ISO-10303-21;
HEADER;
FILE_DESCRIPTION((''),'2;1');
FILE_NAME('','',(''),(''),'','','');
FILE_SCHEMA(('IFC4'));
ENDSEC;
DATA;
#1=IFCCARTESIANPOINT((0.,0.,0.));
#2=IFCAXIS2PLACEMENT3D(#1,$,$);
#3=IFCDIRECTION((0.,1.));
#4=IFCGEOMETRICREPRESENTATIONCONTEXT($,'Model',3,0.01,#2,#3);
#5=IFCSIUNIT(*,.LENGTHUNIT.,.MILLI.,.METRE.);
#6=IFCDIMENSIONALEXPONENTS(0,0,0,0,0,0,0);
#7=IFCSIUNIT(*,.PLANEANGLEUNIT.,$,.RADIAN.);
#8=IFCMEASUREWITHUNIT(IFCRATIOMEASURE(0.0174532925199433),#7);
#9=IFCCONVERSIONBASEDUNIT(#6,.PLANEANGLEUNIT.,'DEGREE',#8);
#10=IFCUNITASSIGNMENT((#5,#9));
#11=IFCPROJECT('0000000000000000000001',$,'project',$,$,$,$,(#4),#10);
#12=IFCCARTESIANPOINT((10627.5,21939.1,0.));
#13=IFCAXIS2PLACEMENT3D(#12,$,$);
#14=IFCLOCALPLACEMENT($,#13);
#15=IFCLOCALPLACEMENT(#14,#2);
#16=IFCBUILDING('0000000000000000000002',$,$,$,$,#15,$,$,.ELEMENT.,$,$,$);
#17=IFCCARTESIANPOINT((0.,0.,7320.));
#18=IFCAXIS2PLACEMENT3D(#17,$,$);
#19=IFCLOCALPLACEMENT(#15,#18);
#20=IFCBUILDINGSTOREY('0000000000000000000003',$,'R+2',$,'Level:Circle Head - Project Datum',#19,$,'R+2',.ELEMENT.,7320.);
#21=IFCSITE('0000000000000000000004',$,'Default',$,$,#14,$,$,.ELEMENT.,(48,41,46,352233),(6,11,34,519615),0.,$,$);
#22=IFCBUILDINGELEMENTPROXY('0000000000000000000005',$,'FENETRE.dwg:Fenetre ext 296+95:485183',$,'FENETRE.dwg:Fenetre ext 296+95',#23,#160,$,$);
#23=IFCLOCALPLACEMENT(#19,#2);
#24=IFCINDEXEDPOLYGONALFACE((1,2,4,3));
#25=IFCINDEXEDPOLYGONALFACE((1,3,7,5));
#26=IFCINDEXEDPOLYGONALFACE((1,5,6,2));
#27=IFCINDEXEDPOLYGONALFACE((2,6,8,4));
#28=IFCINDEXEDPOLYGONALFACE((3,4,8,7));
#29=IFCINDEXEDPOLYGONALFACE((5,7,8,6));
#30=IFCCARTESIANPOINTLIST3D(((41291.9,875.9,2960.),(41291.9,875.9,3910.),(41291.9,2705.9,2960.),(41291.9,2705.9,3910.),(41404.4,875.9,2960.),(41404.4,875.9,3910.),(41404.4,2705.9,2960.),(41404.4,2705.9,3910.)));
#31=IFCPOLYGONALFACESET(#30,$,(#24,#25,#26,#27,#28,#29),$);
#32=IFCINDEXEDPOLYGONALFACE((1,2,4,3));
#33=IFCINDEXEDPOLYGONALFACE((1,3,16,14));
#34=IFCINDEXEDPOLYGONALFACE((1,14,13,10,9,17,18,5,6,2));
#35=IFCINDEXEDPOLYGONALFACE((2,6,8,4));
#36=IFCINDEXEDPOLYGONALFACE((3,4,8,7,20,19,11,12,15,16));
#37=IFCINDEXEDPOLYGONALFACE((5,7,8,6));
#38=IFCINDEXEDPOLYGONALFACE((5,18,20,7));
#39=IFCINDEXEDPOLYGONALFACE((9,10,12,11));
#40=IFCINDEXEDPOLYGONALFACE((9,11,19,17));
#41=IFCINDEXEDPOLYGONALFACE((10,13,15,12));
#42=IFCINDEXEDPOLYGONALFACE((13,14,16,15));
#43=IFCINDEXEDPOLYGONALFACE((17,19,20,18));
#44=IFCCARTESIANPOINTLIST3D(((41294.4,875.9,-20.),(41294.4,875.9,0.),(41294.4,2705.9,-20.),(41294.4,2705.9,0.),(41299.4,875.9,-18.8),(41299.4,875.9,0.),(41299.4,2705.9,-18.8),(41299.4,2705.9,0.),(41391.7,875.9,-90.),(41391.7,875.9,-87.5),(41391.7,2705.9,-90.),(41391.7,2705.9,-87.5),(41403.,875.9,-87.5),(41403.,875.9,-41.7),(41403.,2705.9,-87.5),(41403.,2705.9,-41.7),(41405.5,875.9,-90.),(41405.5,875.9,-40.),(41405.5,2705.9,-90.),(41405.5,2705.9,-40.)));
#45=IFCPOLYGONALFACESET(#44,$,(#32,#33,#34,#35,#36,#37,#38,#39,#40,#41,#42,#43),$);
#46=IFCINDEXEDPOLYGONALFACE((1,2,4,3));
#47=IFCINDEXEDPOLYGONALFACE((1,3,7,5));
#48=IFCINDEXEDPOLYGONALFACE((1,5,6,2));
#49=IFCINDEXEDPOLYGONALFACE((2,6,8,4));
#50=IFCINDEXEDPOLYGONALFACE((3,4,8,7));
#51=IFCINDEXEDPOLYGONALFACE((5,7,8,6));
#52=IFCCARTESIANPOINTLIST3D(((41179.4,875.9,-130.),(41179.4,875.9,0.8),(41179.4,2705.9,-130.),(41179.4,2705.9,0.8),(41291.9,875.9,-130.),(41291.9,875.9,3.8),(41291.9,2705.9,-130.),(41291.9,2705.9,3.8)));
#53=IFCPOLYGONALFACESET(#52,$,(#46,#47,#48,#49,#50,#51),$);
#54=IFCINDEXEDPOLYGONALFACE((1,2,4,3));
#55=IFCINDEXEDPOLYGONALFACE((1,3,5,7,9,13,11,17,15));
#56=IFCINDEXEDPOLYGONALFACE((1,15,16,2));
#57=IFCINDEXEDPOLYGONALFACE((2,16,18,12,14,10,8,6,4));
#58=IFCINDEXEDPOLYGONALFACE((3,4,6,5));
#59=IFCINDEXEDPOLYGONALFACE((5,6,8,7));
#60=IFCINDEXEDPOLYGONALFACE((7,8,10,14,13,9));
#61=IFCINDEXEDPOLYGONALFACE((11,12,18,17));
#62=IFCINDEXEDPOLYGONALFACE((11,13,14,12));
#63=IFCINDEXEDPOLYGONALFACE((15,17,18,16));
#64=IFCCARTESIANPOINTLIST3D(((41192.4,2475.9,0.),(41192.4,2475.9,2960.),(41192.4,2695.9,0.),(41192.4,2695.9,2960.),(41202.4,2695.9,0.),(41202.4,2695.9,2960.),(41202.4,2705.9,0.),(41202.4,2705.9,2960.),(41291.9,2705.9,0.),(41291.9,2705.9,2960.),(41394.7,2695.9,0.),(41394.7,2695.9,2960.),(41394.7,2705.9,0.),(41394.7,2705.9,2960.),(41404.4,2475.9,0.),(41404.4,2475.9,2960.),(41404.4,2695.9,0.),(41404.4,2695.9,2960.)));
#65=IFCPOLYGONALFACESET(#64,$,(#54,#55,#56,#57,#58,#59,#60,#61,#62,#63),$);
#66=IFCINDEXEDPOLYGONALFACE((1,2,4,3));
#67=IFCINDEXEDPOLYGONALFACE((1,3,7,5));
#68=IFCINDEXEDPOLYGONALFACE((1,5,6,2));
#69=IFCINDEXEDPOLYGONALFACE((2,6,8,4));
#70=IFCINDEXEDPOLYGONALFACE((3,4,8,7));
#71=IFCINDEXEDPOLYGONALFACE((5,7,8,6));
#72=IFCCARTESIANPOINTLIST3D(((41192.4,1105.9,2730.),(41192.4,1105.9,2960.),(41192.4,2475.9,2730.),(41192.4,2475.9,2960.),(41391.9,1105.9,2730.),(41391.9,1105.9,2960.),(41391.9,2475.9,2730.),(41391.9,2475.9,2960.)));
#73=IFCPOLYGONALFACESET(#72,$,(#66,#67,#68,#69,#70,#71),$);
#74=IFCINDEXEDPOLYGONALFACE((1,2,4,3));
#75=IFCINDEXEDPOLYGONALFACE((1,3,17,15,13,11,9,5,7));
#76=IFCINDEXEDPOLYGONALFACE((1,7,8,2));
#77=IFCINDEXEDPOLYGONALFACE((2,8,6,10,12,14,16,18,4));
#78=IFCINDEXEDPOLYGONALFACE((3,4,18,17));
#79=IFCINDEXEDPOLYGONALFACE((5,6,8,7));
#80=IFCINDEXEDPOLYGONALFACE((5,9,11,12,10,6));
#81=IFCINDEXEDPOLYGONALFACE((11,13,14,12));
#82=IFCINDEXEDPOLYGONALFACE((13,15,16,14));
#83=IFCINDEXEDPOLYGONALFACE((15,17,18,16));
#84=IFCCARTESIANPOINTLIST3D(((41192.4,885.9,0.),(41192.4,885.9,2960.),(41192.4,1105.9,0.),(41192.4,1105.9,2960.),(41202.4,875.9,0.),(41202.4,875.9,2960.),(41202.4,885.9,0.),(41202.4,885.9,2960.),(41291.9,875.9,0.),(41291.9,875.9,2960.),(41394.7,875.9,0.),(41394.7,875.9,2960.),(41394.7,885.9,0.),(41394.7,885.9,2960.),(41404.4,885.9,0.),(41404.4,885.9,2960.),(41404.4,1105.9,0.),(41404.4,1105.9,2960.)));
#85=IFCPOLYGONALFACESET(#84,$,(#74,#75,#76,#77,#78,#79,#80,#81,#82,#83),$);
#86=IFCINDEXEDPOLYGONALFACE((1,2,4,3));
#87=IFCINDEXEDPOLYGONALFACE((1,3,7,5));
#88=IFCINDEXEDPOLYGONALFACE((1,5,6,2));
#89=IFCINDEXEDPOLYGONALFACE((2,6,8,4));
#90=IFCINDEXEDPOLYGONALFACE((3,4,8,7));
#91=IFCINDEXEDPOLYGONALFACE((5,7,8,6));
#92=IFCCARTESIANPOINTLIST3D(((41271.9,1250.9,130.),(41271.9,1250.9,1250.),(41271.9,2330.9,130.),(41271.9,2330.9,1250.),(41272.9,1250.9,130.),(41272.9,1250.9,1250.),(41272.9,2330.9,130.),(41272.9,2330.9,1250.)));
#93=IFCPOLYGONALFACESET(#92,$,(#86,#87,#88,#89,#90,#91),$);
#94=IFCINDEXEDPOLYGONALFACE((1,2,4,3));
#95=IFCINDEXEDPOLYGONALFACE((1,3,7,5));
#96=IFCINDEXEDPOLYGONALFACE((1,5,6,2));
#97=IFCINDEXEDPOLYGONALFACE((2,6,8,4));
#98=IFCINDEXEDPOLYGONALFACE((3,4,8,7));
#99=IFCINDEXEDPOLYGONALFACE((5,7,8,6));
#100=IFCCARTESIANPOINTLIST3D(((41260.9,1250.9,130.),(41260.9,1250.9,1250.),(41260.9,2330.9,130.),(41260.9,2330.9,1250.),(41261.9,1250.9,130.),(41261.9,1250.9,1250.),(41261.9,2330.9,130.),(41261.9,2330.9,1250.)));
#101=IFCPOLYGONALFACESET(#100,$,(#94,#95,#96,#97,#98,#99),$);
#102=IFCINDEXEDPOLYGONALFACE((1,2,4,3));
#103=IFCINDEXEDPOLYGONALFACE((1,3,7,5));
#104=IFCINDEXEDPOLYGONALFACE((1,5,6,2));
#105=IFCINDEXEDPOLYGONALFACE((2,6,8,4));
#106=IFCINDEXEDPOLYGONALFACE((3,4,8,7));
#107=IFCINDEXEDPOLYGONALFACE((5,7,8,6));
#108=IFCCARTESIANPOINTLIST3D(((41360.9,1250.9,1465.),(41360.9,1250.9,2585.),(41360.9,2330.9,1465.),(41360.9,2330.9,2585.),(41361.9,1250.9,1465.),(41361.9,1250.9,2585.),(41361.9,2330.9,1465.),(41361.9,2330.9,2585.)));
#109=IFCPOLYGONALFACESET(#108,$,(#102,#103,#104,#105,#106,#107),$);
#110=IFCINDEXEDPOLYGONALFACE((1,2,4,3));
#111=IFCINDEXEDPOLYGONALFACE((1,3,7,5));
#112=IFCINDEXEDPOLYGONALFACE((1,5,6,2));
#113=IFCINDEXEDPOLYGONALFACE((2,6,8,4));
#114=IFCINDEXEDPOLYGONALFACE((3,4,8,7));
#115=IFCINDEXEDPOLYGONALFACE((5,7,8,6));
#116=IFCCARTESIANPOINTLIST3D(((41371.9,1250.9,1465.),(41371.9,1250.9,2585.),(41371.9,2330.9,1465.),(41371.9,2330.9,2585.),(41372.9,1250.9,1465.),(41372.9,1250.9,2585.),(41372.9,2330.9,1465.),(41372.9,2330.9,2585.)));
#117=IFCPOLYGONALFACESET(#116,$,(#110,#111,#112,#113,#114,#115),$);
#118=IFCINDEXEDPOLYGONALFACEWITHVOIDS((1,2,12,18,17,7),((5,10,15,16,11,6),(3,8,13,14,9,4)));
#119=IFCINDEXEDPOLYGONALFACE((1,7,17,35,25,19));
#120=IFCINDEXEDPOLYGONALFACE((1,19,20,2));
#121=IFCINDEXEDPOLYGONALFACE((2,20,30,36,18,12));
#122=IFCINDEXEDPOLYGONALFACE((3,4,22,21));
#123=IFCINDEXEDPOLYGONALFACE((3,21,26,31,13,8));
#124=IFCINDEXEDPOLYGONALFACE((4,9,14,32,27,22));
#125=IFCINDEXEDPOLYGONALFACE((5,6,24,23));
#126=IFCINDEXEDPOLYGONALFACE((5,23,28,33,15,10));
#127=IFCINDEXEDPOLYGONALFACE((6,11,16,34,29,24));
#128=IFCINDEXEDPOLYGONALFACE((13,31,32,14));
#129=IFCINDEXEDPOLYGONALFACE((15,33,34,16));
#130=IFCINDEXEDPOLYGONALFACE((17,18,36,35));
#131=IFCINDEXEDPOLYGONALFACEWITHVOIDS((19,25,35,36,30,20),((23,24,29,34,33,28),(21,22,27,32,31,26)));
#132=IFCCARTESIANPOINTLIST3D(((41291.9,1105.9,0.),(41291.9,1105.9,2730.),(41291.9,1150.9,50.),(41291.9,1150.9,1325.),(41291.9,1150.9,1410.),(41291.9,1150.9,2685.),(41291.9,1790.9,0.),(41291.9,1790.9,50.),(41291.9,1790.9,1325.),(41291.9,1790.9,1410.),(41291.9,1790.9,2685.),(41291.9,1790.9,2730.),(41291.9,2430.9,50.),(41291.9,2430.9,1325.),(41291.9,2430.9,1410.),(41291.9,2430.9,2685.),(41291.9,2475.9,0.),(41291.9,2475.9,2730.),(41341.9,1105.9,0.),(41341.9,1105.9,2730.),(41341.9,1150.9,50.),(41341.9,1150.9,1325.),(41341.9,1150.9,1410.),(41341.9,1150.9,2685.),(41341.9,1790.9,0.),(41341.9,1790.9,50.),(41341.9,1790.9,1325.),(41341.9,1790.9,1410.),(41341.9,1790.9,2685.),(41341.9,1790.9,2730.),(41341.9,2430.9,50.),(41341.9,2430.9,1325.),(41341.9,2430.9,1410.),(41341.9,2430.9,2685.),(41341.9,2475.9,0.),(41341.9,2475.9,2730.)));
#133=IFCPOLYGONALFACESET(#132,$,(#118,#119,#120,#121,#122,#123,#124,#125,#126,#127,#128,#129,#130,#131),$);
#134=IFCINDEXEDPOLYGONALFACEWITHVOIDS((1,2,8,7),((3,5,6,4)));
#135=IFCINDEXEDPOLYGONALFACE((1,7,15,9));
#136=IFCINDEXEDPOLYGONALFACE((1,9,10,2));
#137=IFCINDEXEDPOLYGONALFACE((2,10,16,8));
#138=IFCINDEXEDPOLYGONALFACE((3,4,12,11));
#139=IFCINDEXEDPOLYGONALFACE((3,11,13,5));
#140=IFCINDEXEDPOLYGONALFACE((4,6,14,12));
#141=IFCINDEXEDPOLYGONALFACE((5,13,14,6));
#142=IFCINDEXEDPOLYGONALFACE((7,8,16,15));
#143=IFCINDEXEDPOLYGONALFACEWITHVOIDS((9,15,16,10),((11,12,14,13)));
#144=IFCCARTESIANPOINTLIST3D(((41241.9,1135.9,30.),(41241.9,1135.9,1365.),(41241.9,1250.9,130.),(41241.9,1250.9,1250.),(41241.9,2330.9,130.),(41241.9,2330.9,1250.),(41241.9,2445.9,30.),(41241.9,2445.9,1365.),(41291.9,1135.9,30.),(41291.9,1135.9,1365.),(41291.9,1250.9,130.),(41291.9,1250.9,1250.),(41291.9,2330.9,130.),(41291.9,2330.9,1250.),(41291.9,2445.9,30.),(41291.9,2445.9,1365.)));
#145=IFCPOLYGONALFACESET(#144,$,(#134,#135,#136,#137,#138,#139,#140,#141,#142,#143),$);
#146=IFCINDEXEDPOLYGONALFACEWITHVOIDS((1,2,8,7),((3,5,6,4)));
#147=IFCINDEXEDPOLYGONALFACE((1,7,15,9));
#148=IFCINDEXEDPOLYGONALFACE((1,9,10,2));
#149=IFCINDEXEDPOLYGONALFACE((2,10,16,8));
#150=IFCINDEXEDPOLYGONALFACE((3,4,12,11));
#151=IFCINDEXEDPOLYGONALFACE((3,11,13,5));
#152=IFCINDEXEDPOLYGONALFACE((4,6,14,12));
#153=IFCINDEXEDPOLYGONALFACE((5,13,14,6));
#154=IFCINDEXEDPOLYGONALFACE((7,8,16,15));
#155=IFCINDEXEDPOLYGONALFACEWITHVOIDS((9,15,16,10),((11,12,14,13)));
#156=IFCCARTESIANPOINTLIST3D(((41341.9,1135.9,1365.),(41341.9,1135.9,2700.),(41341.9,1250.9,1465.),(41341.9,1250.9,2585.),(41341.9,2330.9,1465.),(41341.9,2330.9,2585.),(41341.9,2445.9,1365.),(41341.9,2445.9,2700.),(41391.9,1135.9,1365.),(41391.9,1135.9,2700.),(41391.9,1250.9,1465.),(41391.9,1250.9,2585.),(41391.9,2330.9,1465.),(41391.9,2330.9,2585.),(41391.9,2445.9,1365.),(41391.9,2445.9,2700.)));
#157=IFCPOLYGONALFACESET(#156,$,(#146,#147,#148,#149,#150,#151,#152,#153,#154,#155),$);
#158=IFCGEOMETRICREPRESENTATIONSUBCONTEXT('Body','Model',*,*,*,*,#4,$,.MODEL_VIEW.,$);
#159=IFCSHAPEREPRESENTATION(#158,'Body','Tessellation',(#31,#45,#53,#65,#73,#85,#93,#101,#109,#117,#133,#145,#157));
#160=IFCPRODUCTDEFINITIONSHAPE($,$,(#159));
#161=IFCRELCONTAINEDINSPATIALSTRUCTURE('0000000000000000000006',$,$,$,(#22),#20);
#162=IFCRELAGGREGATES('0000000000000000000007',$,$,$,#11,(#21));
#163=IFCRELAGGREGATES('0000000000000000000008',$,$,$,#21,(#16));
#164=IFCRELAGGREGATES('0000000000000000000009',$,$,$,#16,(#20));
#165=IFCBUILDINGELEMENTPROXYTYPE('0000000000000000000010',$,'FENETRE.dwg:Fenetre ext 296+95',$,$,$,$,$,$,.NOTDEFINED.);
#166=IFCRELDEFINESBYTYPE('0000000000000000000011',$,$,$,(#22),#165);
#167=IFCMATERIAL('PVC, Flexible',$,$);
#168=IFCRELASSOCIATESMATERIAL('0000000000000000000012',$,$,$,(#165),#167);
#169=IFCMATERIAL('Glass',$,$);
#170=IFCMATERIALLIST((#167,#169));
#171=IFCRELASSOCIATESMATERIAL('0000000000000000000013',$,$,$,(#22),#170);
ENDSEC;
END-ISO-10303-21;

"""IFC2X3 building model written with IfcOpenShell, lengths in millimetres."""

from ifc_helpers import new_model, entity, si_unit, converted_unit, direction, frame, frame_2d, origin, origin_2d_with_axis, place, context, subcontext, project, spatial, polyline, rectangle, outline, extrude, source, transform, mapped, material, material_list, type_object, type_shapes, element, save


model = new_model("IFC2X3")

# Units and contexts
model_context = context("Model", 3, precision=0.01, world=origin(), true_north=direction((0.0, 1.0)))
body_context = subcontext(model_context, "Body", "Model", "MODEL_VIEW")
ifc_project = project(units=[si_unit("LENGTHUNIT", "METRE", prefix="MILLI"), converted_unit("PLANEANGLEUNIT", "DEGREE", entity("IfcRatioMeasure", 0.0174532925199433), si_unit("PLANEANGLEUNIT", "RADIAN"), dimensions=[0, 0, 0, 0, 0, 0, 0])], contexts=[model_context])

# Site, building, storey
site_placement = place(None, frame((10627.5, 21939.1, 0.0)))
site = spatial("IfcSite", under=ifc_project, at=site_placement, Name="Default", CompositionType="ELEMENT", RefLatitude=(48, 41, 46, 352233), RefLongitude=(6, 11, 34, 519615), RefElevation=0.0)
building_placement = place(site_placement, origin())
building = spatial("IfcBuilding", under=site, at=building_placement, CompositionType="ELEMENT")
storey_placement = place(building_placement, frame((0.0, 0.0, 7320.0)))
storey = spatial("IfcBuildingStorey", under=building, at=storey_placement, Name="R+2", ObjectType="Level:Circle Head - Project Datum", LongName="R+2", CompositionType="ELEMENT", Elevation=7320.0)

# Building element proxy
ifc_material_1 = material(Name="PVC, Flexible")
ifc_material_2 = material(Name="Glass")
building_element_proxy_type_1 = type_object("IfcBuildingElementProxyType", Name="FENETRE.dwg:Fenetre ext 296+95", PredefinedType="NOTDEFINED", material=ifc_material_1)
shared_shape_1 = source(origin(), body_context, "Body", "SweptSolid", [
    extrude(rectangle(XDim=112.5, YDim=1830.0, at=origin_2d_with_axis()), frame((-10.4, -56.3, 2960.0), z_axis=(0.0, 0.0, 1.0), x_axis=(0.0, 1.0, 0.0)), (0.0, 0.0, 1.0), 950.0),
    extrude(outline(polyline([(27.5, -64.4), (47.5, -64.4), (47.5, -59.4), (28.8, -59.4), (7.5, 46.7), (-42.5, 46.7), (-42.5, 32.9), (-40.0, 32.9), (-40.0, 44.2), (5.8, 44.2), (27.5, -64.4)])), frame((-925.4, -66.9, -47.5), z_axis=(1.0, 0.0, 0.0), x_axis=(0.0, 0.0, 1.0)), (0.0, 0.0, 1.0), 1830.0),
    extrude(outline(polyline([(-54.5, -66.1), (58.0, -66.1), (54.5, 67.6), (-58.0, 64.6), (-54.5, -66.1)])), frame((-925.4, 56.3, -63.8), z_axis=(1.0, 0.0, 0.0), x_axis=(0.0, -0.999645, 0.02665)), (0.0, 0.0, 1.0), 1830.0),
    extrude(outline(polyline([(-97.0, -55.6), (5.9, -55.6), (95.4, -55.6), (95.4, -45.6), (105.4, -45.6), (105.4, 174.4), (-106.6, 174.4), (-106.6, -45.6), (-97.0, -45.6), (-97.0, -55.6)])), frame((849.0, -5.9, 0.0), z_axis=(0.0, 0.0, 1.0), x_axis=(0.0, 1.0, 0.0)), (0.0, 0.0, 1.0), 2960.0),
    extrude(rectangle(XDim=1370.0, YDim=199.5, at=origin_2d_with_axis()), frame((-10.4, -0.3, 2730.0), z_axis=(0.0, 0.0, 1.0), x_axis=(-1.0, 0.0, 0.0)), (0.0, 0.0, 1.0), 230.0),
    extrude(outline(polyline([(-55.6, 97.0), (-55.6, -5.9), (-55.6, -95.4), (-45.6, -95.4), (-45.6, -105.4), (174.4, -105.4), (174.4, 106.6), (-45.6, 106.6), (-45.6, 97.0), (-55.6, 97.0)])), frame((-869.9, -5.9, 0.0), z_axis=(0.0, 0.0, -1.0), x_axis=(1.0, 0.0, 0.0)), (0.0, 0.0, -1.0), 2960.0),
    extrude(rectangle(XDim=1080.0, YDim=1.0, at=origin_2d_with_axis()), frame((-10.4, 19.5, 130.0), z_axis=(0.0, 0.0, 1.0), x_axis=(-1.0, 0.0, 0.0)), (0.0, 0.0, 1.0), 1120.0),
    extrude(rectangle(XDim=1080.0, YDim=1.0, at=origin_2d_with_axis()), frame((-10.4, 30.5, 130.0), z_axis=(0.0, 0.0, 1.0), x_axis=(-1.0, 0.0, 0.0)), (0.0, 0.0, 1.0), 1120.0),
    extrude(rectangle(XDim=1080.0, YDim=1.0, at=frame_2d((0.0, 0.0), x_axis=(1.0, 0.0))), frame((-10.4, -69.5, 1465.0), z_axis=(0.0, 0.0, 1.0), x_axis=(-1.0, 0.0, 0.0)), (0.0, 0.0, 1.0), 1120.0),
    extrude(rectangle(XDim=1080.0, YDim=1.0, at=frame_2d((0.0, 0.0), x_axis=(1.0, 0.0))), frame((-10.4, -80.5, 1465.0), z_axis=(0.0, 0.0, 1.0), x_axis=(-1.0, 0.0, 0.0)), (0.0, 0.0, 1.0), 1120.0),
    extrude(outline(polyline([(-685.0, -1365.0), (0.0, -1365.0), (685.0, -1365.0), (685.0, 1365.0), (0.0, 1365.0), (-685.0, 1365.0), (-685.0, -1365.0)]), holes=[polyline([(-640.0, -1320.0), (-640.0, -45.0), (0.0, -45.0), (640.0, -45.0), (640.0, -1320.0), (0.0, -1320.0), (-640.0, -1320.0)]), polyline([(-640.0, 40.0), (-640.0, 1315.0), (0.0, 1315.0), (640.0, 1315.0), (640.0, 40.0), (0.0, 40.0), (-640.0, 40.0)])]), frame((-10.4, -50.0, 1365.0), z_axis=(0.0, 1.0, 0.0), x_axis=(1.0, 0.0, 0.0)), (0.0, 0.0, 1.0), 50.0),
    extrude(outline(polyline([(-655.0, -667.5), (655.0, -667.5), (655.0, 667.5), (-655.0, 667.5), (-655.0, -667.5)]), holes=[polyline([(-540.0, 552.5), (540.0, 552.5), (540.0, -567.5), (-540.0, -567.5), (-540.0, 552.5)])]), frame((-10.4, 0.0, 697.5), z_axis=(0.0, 1.0, 0.0), x_axis=(-1.0, 0.0, 0.0)), (0.0, 0.0, 1.0), 50.0),
    extrude(outline(polyline([(-655.0, -667.5), (655.0, -667.5), (655.0, 667.5), (-655.0, 667.5), (-655.0, -667.5)]), holes=[polyline([(-540.0, 552.5), (540.0, 552.5), (540.0, -567.5), (-540.0, -567.5), (-540.0, 552.5)])]), frame((-10.4, -100.0, 2032.5), z_axis=(0.0, 1.0, 0.0), x_axis=(-1.0, 0.0, 0.0)), (0.0, 0.0, 1.0), 50.0),
])
type_shapes(building_element_proxy_type_1, [shared_shape_1])
ifc_material_list_1 = material_list([ifc_material_1, ifc_material_2])
proxy_1_placement = place(storey_placement, frame((41291.9, 1801.3, 0.0), z_axis=(0.0, 0.0, 1.0), x_axis=(0.0, 1.0, 0.0)))
element("IfcBuildingElementProxy", 1, at=proxy_1_placement, inside=storey, type_object=building_element_proxy_type_1, material=ifc_material_list_1, Name="FENETRE.dwg:Fenetre ext 296+95:485183", ObjectType="FENETRE.dwg:Fenetre ext 296+95", context=body_context, shape_type="MappedRepresentation", body=[
    mapped(shared_shape_1, transform((0.0, 0.0, 0.0), scale=1.0)),
])

save(model, "model.ifc")
